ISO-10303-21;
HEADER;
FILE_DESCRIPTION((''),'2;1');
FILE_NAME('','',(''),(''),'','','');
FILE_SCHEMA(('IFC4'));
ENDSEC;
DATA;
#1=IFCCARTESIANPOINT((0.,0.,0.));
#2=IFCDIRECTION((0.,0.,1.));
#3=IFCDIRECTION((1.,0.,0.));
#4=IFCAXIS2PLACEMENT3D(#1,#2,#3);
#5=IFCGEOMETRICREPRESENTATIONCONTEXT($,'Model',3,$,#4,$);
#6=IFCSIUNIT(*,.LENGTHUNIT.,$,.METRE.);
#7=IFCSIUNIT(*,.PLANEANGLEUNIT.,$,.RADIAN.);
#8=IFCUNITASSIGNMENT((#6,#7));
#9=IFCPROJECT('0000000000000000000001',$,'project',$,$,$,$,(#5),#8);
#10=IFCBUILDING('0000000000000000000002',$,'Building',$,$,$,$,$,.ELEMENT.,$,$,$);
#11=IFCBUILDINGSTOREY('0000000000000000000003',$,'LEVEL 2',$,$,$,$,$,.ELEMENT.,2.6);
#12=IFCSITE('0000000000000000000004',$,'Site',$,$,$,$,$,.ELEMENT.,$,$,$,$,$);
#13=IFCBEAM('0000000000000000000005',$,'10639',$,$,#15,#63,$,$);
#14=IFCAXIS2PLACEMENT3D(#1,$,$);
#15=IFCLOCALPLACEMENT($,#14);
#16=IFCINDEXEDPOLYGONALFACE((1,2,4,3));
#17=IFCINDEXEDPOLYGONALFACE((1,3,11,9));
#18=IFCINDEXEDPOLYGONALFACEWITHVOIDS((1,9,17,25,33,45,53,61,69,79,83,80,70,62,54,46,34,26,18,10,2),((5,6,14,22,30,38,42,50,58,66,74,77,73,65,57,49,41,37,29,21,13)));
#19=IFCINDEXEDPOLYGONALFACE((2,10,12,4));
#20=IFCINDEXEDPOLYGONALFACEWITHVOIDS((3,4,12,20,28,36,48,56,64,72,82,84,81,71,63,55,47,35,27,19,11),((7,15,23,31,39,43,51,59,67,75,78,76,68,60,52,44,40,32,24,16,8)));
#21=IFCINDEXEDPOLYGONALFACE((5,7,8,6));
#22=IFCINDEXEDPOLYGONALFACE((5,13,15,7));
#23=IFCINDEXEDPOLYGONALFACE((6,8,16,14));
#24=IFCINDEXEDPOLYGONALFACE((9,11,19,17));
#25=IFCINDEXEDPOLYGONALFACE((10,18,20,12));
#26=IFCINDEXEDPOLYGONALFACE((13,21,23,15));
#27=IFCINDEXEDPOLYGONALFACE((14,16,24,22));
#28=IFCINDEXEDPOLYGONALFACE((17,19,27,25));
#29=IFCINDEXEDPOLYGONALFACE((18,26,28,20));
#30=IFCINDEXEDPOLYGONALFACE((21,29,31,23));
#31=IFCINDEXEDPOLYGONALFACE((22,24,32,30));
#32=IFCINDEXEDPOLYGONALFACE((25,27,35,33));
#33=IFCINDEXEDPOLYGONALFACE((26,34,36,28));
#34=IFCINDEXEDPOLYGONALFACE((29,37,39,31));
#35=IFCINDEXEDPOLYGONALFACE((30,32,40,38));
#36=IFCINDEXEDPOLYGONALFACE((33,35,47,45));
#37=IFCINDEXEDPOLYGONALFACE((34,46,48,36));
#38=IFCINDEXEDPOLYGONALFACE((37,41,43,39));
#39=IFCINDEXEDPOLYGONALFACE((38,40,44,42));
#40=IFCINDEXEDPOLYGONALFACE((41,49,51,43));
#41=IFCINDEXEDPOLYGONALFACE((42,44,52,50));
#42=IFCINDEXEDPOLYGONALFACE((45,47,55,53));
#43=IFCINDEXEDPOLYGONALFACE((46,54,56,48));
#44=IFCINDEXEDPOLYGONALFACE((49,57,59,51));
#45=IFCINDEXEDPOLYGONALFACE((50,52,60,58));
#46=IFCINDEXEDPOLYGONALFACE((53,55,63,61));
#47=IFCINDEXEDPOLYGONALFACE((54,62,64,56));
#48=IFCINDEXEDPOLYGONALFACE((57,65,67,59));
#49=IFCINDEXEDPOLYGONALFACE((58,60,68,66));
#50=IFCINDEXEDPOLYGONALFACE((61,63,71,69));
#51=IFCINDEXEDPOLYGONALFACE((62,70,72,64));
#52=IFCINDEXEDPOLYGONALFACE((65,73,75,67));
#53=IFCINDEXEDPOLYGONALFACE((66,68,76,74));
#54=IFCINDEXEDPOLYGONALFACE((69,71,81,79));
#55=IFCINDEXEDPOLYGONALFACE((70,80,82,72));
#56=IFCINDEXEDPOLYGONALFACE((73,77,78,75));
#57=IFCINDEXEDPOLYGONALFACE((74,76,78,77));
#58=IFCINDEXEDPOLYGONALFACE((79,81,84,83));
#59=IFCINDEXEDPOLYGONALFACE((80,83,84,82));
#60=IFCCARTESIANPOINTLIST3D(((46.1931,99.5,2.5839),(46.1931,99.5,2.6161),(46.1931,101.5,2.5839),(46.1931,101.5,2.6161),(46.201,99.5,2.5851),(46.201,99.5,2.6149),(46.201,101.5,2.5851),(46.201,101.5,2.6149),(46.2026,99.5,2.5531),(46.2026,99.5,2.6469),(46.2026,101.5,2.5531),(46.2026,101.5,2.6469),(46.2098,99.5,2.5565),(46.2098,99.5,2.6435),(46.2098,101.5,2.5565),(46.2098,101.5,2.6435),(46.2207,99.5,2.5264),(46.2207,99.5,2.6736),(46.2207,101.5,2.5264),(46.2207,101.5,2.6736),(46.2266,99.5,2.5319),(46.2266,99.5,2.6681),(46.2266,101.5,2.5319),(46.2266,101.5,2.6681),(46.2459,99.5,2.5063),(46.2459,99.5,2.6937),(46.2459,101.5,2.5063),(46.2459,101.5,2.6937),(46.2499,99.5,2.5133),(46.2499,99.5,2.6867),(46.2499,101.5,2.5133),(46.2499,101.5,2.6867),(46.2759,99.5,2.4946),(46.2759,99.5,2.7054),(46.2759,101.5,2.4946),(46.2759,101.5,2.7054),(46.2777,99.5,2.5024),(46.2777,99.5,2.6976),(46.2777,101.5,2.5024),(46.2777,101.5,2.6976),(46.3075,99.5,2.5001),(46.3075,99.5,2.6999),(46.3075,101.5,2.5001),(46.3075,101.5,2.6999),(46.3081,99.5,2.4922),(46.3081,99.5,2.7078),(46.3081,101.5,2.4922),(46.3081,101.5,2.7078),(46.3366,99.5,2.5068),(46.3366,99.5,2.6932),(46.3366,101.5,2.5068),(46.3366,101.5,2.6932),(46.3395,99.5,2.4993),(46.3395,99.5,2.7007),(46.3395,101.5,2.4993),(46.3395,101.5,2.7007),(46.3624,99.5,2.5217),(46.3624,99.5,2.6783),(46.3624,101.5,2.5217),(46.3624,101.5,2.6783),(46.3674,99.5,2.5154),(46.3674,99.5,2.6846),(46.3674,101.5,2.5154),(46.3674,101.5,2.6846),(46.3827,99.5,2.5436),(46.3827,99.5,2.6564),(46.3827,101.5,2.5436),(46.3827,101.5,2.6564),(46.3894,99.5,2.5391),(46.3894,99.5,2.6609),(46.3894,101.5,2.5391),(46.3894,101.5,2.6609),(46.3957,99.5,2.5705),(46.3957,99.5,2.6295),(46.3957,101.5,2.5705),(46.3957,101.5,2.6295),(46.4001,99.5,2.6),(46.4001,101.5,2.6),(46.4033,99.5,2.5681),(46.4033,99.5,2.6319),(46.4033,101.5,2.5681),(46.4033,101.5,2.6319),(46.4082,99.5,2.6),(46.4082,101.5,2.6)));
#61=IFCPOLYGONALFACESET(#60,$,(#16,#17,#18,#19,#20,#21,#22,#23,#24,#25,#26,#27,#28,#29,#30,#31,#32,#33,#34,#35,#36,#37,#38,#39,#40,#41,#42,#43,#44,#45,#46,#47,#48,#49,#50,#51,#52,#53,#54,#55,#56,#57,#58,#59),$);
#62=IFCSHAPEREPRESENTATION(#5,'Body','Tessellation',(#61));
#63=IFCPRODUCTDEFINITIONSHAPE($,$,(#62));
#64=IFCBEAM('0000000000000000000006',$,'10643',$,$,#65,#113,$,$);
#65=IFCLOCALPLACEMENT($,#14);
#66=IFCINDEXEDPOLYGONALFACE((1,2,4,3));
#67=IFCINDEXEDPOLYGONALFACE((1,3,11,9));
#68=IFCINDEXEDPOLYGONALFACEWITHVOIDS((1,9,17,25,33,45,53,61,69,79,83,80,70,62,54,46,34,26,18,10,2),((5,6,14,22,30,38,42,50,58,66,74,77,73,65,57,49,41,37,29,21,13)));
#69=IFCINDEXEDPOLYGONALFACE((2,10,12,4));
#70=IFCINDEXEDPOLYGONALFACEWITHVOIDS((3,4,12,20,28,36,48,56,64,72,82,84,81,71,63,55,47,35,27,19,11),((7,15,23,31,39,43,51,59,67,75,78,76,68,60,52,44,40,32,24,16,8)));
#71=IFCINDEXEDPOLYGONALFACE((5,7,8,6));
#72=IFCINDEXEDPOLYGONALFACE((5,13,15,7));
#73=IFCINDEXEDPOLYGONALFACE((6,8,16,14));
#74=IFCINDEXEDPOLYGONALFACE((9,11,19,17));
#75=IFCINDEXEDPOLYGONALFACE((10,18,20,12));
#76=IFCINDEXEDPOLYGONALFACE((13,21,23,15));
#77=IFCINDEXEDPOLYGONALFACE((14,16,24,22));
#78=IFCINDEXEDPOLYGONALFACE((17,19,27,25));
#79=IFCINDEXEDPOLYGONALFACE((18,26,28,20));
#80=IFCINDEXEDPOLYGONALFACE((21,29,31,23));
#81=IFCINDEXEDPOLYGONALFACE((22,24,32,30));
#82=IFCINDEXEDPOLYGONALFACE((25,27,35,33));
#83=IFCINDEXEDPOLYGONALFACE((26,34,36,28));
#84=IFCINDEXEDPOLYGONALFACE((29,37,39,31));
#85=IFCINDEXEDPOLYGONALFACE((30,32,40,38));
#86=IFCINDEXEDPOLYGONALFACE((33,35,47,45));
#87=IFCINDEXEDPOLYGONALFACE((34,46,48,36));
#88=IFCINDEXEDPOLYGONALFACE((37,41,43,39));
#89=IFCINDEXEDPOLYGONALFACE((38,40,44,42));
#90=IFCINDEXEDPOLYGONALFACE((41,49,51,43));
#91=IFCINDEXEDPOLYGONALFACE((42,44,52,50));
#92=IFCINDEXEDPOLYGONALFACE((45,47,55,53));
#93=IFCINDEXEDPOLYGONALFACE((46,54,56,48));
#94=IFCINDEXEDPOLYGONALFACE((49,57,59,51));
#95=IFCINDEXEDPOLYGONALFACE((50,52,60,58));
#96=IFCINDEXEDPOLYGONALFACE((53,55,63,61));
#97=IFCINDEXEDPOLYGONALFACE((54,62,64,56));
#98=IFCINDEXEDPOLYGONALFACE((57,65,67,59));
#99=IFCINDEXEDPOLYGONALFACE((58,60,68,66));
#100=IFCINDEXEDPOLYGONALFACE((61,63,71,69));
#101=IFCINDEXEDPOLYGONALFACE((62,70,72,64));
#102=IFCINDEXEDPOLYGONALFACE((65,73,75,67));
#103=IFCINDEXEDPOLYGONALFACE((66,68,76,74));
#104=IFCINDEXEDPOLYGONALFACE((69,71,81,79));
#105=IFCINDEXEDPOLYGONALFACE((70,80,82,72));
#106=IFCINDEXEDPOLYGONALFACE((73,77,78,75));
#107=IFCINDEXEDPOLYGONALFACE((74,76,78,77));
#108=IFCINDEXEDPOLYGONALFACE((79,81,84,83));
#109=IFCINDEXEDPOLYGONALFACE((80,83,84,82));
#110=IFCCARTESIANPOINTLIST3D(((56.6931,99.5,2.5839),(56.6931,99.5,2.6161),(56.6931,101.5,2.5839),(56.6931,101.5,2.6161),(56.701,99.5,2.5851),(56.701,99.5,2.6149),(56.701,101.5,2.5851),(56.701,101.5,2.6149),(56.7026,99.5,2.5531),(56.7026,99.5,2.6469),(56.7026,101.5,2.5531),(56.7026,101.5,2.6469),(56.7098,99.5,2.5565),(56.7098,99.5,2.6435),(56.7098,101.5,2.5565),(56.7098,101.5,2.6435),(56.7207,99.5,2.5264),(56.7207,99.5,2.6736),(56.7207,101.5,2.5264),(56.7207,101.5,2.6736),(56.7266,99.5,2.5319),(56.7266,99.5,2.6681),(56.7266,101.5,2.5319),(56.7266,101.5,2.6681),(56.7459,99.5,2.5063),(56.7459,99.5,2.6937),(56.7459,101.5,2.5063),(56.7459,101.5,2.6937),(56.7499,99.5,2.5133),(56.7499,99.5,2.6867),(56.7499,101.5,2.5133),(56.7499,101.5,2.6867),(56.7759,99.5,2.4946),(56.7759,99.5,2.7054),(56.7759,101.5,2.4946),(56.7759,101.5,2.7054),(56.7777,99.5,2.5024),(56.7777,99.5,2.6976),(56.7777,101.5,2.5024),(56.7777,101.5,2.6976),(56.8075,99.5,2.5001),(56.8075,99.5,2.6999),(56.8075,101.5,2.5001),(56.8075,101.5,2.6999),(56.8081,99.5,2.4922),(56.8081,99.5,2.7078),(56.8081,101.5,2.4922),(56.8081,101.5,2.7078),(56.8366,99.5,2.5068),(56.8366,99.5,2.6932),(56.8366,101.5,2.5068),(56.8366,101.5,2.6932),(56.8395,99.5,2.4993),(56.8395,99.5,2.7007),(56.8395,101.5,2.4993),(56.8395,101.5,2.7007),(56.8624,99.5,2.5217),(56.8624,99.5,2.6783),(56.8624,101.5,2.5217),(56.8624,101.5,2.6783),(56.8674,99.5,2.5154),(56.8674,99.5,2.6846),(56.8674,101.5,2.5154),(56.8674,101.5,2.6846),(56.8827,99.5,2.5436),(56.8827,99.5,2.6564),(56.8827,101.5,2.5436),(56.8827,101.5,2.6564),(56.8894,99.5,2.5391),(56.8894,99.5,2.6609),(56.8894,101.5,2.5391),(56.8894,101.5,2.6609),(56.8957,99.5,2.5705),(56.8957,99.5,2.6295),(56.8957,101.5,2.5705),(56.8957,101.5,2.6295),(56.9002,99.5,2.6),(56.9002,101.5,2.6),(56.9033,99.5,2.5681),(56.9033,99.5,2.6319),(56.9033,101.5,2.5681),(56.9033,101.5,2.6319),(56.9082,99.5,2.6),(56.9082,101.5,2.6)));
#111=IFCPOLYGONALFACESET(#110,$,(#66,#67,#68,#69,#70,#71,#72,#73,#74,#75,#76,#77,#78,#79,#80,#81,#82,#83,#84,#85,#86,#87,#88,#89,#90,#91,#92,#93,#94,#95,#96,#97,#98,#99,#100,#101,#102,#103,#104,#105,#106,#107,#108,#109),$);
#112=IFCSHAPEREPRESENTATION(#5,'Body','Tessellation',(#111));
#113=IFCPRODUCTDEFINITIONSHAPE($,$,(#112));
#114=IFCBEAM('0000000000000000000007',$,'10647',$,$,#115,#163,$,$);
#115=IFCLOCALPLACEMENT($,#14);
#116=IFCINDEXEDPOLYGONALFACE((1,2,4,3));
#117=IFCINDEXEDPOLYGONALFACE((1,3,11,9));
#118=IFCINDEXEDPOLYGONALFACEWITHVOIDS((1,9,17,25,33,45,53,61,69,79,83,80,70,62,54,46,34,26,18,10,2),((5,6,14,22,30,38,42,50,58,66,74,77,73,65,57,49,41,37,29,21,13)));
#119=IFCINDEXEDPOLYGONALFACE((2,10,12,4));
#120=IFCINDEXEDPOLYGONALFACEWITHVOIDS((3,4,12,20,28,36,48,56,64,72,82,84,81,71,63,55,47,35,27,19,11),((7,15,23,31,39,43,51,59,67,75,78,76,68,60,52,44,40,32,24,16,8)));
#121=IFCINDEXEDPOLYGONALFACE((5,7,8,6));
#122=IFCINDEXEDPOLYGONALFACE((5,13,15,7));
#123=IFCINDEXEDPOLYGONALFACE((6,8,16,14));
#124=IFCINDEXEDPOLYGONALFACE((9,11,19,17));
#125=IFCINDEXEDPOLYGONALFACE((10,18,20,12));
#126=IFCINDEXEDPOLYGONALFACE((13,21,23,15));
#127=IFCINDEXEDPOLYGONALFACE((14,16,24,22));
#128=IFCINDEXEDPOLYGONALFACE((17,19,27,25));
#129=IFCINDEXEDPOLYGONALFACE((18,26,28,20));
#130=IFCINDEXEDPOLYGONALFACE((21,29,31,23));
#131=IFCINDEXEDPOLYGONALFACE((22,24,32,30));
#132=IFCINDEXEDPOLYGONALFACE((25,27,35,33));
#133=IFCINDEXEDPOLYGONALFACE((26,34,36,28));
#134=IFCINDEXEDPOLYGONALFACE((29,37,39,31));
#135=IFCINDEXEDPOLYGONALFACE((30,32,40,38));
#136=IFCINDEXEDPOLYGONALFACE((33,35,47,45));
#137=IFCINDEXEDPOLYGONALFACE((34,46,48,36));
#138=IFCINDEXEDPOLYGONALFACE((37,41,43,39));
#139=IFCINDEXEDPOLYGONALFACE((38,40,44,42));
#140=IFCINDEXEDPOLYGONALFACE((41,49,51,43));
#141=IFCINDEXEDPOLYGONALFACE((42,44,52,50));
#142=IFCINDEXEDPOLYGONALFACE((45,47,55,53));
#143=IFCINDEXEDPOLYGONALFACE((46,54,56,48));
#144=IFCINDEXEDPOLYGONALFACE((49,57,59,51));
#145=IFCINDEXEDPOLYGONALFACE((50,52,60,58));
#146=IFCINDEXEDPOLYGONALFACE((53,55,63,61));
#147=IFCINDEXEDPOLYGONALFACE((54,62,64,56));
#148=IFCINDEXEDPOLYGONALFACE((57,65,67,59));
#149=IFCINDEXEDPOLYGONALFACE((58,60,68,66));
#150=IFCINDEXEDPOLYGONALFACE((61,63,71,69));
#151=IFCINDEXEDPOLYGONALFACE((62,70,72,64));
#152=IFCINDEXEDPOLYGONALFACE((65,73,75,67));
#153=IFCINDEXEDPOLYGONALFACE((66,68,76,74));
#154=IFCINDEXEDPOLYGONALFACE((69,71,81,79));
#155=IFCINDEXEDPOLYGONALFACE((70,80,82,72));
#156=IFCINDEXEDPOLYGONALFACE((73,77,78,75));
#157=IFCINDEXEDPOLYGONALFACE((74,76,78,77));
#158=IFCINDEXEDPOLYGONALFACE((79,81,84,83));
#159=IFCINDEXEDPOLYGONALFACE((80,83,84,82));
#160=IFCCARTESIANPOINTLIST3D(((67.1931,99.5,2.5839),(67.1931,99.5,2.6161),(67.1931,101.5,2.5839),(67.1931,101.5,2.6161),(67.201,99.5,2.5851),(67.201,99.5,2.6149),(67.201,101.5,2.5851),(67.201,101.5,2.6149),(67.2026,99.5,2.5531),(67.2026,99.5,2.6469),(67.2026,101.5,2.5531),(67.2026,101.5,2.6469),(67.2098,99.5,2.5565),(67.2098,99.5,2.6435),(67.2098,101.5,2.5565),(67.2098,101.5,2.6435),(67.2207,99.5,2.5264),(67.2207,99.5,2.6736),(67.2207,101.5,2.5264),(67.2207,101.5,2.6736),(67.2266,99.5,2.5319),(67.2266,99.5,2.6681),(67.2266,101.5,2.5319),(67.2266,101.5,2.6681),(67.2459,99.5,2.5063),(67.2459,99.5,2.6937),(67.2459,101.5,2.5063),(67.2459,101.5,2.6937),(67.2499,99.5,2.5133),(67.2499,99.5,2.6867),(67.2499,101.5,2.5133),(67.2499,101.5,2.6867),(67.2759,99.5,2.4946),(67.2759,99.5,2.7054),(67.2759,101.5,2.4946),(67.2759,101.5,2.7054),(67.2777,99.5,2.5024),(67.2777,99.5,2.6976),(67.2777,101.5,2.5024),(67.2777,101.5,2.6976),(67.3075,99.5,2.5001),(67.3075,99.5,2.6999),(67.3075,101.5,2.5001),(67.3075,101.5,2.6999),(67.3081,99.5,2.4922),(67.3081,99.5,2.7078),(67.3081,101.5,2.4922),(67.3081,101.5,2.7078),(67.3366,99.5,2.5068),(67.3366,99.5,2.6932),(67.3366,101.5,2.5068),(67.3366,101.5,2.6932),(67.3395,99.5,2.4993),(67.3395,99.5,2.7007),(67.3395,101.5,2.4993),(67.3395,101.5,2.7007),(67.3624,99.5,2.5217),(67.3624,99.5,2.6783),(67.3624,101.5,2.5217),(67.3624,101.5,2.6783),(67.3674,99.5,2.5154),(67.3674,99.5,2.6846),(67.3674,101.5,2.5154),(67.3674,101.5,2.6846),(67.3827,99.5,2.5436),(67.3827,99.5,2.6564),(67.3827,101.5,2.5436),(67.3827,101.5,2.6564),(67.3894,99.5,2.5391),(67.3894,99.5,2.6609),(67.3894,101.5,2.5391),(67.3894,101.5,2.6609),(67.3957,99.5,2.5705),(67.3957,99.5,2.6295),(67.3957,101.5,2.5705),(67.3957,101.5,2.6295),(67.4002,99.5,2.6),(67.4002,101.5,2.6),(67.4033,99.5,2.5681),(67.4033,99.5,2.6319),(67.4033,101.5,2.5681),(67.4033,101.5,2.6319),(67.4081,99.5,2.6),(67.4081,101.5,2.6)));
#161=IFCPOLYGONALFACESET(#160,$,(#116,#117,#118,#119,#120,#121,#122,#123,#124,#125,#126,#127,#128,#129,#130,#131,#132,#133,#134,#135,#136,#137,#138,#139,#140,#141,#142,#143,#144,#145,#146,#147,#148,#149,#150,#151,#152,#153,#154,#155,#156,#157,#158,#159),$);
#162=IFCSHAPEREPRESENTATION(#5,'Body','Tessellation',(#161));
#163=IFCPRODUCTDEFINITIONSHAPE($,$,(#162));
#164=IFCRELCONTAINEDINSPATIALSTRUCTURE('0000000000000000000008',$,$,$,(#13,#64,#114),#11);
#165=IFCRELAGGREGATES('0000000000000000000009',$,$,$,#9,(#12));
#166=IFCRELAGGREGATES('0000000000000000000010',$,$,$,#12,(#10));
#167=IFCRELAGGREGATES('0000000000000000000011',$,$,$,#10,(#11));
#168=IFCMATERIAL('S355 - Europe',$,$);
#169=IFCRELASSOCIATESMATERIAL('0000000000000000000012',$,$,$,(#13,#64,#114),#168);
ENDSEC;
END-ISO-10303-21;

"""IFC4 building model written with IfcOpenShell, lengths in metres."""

from ifc_helpers import new_model, si_unit, frame, origin_with_axes, origin_2d_with_axis, place, context, project, spatial, hollow_circle, extrude, material, material_profile, profile_set, profile_usage, element, save


model = new_model("IFC4")

# Units and contexts
model_context = context("Model", 3, world=origin_with_axes())
ifc_project = project(units=[si_unit("LENGTHUNIT", "METRE"), si_unit("PLANEANGLEUNIT", "RADIAN")], contexts=[model_context])

# Site, building, storey
site = spatial("IfcSite", under=ifc_project, Name="Site", CompositionType="ELEMENT")
building = spatial("IfcBuilding", under=site, Name="Building", CompositionType="ELEMENT")
storey = spatial("IfcBuildingStorey", under=building, Name="LEVEL 2", CompositionType="ELEMENT", Elevation=2.6)

# Shared definitions
ifc_material = material(Name="S355 - Europe")

# Beams
ifc_material_profile_1 = material_profile(ifc_material, hollow_circle(Radius=0.1081, WallThickness=0.008, at=origin_2d_with_axis()))
ifc_profile_set_1 = profile_set([ifc_material_profile_1])
ifc_profile_usage_1 = profile_usage(ifc_profile_set_1, cardinal=10)
beam_1_placement = place(None, frame((46.3, 101.5, 2.6), z_axis=(0.0, -1.0, 0.0), x_axis=(1.0, 0.0, 0.0)))
element("IfcBeam", 1, at=beam_1_placement, inside=storey, material=ifc_profile_usage_1, Name="10639", context=model_context, shape_type="SweptSolid", body=[
    extrude(hollow_circle(Radius=0.1081, WallThickness=0.008, at=origin_2d_with_axis()), origin_with_axes(), (0.0, 0.0, 1.0), 2.0),
])
ifc_material_profile_2 = material_profile(ifc_material, hollow_circle(Radius=0.1081, WallThickness=0.008, at=origin_2d_with_axis()))
ifc_profile_set_2 = profile_set([ifc_material_profile_2])
ifc_profile_usage_2 = profile_usage(ifc_profile_set_2, cardinal=10)
beam_2_placement = place(None, frame((56.8, 101.5, 2.6), z_axis=(0.0, -1.0, 0.0), x_axis=(1.0, 0.0, 0.0)))
element("IfcBeam", 2, at=beam_2_placement, inside=storey, material=ifc_profile_usage_2, Name="10643", context=model_context, shape_type="SweptSolid", body=[
    extrude(hollow_circle(Radius=0.1081, WallThickness=0.008, at=origin_2d_with_axis()), origin_with_axes(), (0.0, 0.0, 1.0), 2.0),
])
ifc_material_profile_3 = material_profile(ifc_material, hollow_circle(Radius=0.1081, WallThickness=0.008, at=origin_2d_with_axis()))
ifc_profile_set_3 = profile_set([ifc_material_profile_3])
ifc_profile_usage_3 = profile_usage(ifc_profile_set_3, cardinal=10)
beam_3_placement = place(None, frame((67.3, 101.5, 2.6), z_axis=(0.0, -1.0, 0.0), x_axis=(1.0, 0.0, 0.0)))
element("IfcBeam", 3, at=beam_3_placement, inside=storey, material=ifc_profile_usage_3, Name="10647", context=model_context, shape_type="SweptSolid", body=[
    extrude(hollow_circle(Radius=0.1081, WallThickness=0.008, at=origin_2d_with_axis()), origin_with_axes(), (0.0, 0.0, 1.0), 2.0),
])

save(model, "model.ifc")
